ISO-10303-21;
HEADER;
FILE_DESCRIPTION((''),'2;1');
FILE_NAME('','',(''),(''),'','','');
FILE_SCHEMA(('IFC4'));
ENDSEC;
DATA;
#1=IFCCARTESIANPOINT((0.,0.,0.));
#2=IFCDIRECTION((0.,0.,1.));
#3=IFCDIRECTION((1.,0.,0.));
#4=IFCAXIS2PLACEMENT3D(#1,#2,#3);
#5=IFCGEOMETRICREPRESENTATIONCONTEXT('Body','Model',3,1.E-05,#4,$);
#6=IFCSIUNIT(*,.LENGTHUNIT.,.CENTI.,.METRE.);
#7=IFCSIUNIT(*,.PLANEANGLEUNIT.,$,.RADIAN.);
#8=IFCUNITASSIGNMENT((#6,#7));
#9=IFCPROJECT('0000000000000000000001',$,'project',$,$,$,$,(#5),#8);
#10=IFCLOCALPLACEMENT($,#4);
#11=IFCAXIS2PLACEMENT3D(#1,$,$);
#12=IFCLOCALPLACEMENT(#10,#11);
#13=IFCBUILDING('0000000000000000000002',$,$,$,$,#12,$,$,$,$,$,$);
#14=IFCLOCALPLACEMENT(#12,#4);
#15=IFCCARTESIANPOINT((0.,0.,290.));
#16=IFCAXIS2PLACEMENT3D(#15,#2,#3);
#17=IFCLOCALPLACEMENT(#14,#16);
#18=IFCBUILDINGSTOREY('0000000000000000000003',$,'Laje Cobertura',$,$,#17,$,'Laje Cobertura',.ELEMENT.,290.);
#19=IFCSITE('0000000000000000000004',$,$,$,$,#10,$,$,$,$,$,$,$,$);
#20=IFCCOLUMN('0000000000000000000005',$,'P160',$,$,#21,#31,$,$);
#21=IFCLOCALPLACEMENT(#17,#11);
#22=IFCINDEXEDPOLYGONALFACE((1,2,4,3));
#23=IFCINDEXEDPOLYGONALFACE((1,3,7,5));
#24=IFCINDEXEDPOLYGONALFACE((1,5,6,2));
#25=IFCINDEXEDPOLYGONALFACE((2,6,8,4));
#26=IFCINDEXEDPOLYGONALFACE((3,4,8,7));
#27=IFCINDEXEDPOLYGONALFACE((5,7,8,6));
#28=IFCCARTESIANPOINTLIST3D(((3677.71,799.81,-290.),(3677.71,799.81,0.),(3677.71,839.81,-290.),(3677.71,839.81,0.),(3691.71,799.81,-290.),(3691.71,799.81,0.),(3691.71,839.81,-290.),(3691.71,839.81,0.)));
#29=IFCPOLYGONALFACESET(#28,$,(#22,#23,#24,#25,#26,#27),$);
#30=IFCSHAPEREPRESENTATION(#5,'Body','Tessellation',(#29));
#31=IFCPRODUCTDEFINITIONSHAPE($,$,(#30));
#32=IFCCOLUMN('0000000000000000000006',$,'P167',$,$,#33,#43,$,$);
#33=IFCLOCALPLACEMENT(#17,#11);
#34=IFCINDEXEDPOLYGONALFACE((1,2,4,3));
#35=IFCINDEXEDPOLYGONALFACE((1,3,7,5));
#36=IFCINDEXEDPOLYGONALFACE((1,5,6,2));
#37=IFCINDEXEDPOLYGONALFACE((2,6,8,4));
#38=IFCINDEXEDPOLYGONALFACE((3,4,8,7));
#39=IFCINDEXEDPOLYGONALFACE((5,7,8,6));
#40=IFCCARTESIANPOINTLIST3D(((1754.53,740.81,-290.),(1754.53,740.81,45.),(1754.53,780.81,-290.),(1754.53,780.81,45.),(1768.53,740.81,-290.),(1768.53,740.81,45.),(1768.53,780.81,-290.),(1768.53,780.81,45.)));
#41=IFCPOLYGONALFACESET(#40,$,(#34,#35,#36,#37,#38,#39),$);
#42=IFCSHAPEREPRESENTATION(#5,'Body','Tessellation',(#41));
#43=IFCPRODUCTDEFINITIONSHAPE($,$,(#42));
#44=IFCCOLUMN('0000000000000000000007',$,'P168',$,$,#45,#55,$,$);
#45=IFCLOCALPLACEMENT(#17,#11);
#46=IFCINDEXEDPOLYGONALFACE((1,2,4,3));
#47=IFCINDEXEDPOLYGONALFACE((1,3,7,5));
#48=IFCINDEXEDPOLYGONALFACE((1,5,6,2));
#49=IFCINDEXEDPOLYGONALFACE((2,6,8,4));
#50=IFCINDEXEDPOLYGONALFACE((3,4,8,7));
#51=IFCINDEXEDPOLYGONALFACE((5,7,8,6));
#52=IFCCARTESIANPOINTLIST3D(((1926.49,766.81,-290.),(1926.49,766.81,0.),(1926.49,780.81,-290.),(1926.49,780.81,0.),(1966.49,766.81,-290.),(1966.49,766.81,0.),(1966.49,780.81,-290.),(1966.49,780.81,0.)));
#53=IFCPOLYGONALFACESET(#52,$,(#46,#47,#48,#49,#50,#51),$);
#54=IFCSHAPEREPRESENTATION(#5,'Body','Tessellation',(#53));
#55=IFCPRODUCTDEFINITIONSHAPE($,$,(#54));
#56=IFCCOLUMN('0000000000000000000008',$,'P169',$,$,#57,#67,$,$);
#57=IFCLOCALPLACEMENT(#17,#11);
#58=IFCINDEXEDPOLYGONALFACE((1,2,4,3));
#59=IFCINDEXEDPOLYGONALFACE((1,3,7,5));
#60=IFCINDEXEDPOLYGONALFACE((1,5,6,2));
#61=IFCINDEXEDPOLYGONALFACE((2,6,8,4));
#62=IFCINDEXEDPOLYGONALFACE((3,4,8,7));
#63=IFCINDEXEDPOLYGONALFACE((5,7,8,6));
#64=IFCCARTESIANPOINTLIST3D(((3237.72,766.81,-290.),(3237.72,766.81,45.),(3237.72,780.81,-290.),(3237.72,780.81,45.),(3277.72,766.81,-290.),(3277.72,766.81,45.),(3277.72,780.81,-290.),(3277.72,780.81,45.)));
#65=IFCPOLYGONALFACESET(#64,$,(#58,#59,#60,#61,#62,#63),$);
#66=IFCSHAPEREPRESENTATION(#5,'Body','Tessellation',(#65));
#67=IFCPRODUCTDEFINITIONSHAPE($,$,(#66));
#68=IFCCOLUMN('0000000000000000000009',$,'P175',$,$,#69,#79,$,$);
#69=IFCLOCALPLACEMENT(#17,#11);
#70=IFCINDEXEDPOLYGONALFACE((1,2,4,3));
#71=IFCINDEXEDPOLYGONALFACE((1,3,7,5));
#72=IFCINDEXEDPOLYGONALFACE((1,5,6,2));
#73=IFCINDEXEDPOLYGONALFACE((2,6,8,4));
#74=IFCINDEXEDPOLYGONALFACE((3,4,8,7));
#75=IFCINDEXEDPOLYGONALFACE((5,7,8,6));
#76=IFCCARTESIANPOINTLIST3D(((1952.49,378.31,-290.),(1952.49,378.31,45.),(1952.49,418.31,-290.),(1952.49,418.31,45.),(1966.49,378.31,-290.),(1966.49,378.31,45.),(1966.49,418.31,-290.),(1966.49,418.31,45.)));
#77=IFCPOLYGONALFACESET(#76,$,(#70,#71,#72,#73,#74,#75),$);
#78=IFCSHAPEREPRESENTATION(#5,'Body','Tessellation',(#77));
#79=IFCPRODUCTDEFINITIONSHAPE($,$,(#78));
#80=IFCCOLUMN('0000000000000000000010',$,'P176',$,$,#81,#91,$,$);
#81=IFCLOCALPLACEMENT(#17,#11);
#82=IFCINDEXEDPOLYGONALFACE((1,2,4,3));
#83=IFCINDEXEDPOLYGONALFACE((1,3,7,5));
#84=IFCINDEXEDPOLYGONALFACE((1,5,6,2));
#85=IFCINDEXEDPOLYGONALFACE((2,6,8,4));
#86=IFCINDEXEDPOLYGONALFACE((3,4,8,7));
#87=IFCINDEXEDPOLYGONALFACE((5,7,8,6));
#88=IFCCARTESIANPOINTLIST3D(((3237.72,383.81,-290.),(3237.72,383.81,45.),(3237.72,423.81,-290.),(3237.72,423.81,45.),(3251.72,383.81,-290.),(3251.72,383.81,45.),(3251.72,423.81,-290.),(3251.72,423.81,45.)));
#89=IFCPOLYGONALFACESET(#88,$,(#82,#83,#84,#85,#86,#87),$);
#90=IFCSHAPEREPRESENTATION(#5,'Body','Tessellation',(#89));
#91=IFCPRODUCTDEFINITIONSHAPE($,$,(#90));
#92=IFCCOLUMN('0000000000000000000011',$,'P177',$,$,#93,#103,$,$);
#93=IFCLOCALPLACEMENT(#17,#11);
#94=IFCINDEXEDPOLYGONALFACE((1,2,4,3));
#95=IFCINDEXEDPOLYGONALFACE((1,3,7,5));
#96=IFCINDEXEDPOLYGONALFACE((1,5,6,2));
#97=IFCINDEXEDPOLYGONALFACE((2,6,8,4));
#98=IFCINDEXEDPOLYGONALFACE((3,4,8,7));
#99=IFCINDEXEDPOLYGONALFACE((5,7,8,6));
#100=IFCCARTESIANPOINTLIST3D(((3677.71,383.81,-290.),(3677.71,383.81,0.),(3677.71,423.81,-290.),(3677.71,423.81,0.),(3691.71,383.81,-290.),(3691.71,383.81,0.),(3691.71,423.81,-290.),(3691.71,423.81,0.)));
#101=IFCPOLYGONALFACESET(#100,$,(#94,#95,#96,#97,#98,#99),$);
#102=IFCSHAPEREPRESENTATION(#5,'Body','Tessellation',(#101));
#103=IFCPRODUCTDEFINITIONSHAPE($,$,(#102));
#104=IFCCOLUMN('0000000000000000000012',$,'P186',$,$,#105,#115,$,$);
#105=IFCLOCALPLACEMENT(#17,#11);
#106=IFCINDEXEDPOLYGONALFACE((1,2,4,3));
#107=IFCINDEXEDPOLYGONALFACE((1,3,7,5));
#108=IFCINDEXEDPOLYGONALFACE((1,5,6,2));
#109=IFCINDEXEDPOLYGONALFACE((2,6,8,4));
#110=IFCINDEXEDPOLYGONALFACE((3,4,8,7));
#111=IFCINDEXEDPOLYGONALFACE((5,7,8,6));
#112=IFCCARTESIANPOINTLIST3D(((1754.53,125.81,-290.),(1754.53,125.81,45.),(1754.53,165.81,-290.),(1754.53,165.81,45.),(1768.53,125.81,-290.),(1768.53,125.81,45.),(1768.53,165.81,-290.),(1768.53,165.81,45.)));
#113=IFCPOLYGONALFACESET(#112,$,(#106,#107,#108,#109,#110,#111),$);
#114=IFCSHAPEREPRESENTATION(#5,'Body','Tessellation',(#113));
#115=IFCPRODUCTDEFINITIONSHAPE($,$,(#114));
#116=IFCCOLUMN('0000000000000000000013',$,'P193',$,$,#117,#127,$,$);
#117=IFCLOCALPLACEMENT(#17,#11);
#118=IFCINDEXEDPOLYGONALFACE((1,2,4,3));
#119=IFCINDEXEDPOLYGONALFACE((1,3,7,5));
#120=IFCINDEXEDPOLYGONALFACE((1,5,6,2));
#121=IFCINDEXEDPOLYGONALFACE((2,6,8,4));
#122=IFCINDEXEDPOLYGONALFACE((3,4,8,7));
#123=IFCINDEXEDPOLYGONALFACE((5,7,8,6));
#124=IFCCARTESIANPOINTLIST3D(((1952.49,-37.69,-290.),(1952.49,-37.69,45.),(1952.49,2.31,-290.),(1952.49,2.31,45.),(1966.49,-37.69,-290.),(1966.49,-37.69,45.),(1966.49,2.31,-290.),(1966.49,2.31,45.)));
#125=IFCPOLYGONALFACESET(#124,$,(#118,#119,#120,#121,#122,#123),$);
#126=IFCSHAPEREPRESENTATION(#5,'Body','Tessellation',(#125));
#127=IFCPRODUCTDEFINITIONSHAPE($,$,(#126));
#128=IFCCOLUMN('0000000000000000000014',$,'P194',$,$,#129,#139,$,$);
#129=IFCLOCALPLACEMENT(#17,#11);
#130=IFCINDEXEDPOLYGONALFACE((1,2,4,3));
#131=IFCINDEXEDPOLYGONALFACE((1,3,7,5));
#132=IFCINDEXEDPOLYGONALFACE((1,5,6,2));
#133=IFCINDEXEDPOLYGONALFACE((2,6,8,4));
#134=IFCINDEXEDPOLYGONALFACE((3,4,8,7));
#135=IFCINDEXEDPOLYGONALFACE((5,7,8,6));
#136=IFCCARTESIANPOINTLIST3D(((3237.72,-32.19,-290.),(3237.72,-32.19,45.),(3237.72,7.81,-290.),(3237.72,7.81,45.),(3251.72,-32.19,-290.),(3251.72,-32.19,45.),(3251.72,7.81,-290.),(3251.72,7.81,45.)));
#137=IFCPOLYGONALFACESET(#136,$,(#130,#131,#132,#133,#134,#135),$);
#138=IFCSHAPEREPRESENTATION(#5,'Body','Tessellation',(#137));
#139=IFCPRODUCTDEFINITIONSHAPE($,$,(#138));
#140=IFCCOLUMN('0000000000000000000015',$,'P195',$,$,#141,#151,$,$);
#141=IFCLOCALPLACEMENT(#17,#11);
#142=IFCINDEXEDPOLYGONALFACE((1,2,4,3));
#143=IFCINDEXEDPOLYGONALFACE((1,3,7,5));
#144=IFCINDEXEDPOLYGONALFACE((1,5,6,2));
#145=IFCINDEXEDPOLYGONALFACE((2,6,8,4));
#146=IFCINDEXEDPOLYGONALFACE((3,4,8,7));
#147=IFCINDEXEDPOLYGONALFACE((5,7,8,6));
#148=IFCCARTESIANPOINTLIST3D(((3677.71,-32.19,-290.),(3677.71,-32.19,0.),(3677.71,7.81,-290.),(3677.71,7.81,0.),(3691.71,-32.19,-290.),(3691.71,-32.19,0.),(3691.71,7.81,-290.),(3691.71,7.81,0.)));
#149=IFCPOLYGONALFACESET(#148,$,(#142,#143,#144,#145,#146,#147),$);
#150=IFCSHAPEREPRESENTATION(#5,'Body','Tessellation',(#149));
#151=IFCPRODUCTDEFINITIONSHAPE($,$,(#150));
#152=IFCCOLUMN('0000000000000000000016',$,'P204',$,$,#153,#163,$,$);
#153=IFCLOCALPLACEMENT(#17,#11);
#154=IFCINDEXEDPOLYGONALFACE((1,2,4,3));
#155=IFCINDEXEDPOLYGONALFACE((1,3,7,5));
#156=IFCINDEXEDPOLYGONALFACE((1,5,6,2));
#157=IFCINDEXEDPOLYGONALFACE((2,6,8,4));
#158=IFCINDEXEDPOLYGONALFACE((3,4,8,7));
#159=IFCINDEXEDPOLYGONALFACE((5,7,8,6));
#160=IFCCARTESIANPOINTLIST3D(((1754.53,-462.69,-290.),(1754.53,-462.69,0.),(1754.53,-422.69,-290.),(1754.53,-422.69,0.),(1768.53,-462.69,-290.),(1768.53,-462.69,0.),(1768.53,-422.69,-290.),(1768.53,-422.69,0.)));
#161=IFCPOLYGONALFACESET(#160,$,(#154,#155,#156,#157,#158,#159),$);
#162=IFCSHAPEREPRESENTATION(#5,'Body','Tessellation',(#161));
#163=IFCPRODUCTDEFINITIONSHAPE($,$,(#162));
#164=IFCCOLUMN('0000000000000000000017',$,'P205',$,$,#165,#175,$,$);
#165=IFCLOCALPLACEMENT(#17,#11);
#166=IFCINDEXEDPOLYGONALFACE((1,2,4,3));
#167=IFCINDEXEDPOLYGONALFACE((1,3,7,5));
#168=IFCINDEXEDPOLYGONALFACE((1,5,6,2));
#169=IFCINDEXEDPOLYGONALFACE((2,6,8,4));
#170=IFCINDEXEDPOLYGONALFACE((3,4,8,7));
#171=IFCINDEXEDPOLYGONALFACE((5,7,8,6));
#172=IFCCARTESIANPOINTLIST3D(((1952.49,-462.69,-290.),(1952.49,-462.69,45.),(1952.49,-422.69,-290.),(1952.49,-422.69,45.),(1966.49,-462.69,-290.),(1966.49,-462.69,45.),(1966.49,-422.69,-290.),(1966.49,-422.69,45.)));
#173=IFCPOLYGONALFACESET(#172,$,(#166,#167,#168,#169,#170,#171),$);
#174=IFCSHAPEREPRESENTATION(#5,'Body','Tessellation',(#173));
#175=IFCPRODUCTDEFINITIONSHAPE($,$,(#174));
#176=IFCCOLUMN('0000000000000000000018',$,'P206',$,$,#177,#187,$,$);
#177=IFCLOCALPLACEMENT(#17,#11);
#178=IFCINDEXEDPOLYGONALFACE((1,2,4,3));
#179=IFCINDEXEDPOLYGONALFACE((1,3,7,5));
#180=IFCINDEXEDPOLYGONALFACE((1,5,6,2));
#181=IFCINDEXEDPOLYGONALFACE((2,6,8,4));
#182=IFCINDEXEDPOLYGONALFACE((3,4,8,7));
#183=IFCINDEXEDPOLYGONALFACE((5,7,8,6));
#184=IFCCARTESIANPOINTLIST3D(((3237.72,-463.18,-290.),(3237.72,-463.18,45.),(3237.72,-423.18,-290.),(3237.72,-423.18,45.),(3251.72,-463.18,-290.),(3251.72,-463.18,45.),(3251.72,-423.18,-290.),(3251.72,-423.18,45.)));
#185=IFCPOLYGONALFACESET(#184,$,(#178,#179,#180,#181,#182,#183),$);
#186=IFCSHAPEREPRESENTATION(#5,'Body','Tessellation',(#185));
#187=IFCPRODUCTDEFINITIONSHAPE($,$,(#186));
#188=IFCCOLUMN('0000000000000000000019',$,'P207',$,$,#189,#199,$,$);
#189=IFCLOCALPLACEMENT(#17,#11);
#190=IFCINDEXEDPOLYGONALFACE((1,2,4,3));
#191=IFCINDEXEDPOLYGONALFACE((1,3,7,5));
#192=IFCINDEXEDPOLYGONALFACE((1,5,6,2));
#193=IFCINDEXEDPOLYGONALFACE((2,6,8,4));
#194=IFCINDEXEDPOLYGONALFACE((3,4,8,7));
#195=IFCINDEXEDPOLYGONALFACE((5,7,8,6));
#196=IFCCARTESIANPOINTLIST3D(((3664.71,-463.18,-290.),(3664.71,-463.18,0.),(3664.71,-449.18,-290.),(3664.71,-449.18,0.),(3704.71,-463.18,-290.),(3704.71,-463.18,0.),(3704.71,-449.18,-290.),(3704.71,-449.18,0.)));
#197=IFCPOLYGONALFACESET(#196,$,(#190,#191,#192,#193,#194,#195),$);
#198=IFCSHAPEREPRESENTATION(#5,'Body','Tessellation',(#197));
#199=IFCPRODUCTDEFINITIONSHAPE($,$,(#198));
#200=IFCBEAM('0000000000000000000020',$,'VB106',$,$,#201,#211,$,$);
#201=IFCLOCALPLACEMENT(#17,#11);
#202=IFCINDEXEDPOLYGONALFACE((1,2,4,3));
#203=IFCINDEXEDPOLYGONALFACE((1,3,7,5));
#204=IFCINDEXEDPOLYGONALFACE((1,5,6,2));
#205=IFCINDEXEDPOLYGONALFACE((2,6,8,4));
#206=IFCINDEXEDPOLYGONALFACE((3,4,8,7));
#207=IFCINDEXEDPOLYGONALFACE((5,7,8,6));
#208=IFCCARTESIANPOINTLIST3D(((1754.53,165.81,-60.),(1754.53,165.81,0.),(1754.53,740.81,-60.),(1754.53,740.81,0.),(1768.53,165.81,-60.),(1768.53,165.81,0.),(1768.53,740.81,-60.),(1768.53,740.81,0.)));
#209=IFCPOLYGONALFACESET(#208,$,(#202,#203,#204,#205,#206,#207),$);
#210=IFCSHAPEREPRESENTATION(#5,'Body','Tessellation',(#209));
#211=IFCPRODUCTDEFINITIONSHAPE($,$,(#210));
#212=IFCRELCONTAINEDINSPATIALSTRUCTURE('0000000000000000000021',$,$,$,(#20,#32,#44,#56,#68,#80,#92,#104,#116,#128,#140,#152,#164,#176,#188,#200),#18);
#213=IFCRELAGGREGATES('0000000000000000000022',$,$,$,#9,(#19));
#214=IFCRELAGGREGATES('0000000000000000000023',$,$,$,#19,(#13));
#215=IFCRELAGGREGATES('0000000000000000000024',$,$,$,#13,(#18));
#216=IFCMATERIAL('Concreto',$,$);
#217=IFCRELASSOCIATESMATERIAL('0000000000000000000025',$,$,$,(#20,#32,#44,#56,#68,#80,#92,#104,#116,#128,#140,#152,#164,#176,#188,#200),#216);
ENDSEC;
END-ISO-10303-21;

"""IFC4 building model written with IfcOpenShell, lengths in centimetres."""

from ifc_helpers import new_model, si_unit, frame, origin, origin_with_axes, origin_2d_with_axis, place, context, project, spatial, rectangle, extrude, material, element, save


model = new_model("IFC4")

# Units and contexts
model_context = context("Model", 3, precision=1e-05, world=origin_with_axes(), identifier="Body")
ifc_project = project(units=[si_unit("LENGTHUNIT", "METRE", prefix="CENTI"), si_unit("PLANEANGLEUNIT", "RADIAN")], contexts=[model_context])

# Site, building, storey
site_placement = place(None, origin_with_axes())
site = spatial("IfcSite", under=ifc_project, at=site_placement)
building_placement = place(site_placement, origin())
building = spatial("IfcBuilding", under=site, at=building_placement)
placement = place(building_placement, origin_with_axes())
storey_placement = place(placement, frame((0.0, 0.0, 290.0), z_axis=(0.0, 0.0, 1.0), x_axis=(1.0, 0.0, 0.0)))
storey = spatial("IfcBuildingStorey", under=building, at=storey_placement, Name="Laje Cobertura", LongName="Laje Cobertura", CompositionType="ELEMENT", Elevation=290.0)

# Columns
ifc_material = material(Name="Concreto")
column_1_placement = place(storey_placement, frame((3684.71, 819.81, 0.0), z_axis=(0.0, 0.0, 1.0), x_axis=(1.0, 0.0, 0.0)))
element("IfcColumn", 1, at=column_1_placement, inside=storey, material=ifc_material, Name="P160", context=model_context, shape_type="SolidModel", body=[
    extrude(rectangle(XDim=14.0, YDim=40.0, at=origin_2d_with_axis()), origin_with_axes(), (0.0, 0.0, -1.0), 290.0),
])
column_2_placement = place(storey_placement, frame((1761.53, 760.81, 45.0), z_axis=(0.0, 0.0, 1.0), x_axis=(1.0, 0.0, 0.0)))
element("IfcColumn", 2, at=column_2_placement, inside=storey, material=ifc_material, Name="P167", context=model_context, shape_type="SolidModel", body=[
    extrude(rectangle(XDim=14.0, YDim=40.0, at=origin_2d_with_axis()), origin_with_axes(), (0.0, 0.0, -1.0), 335.0),
])
column_3_placement = place(storey_placement, frame((1946.49, 773.81, 0.0), z_axis=(0.0, 0.0, 1.0), x_axis=(1.0, 0.0, 0.0)))
element("IfcColumn", 3, at=column_3_placement, inside=storey, material=ifc_material, Name="P168", context=model_context, shape_type="SolidModel", body=[
    extrude(rectangle(XDim=14.0, YDim=40.0, at=origin_2d_with_axis()), frame((0.0, 0.0, 0.0), z_axis=(0.0, 0.0, 1.0), x_axis=(0.0, -1.0, 0.0)), (0.0, 0.0, -1.0), 290.0),
])
column_4_placement = place(storey_placement, frame((3257.72, 773.81, 45.0), z_axis=(0.0, 0.0, 1.0), x_axis=(1.0, 0.0, 0.0)))
element("IfcColumn", 4, at=column_4_placement, inside=storey, material=ifc_material, Name="P169", context=model_context, shape_type="SolidModel", body=[
    extrude(rectangle(XDim=14.0, YDim=40.0, at=origin_2d_with_axis()), frame((0.0, 0.0, 0.0), z_axis=(0.0, 0.0, 1.0), x_axis=(0.0, -1.0, 0.0)), (0.0, 0.0, -1.0), 335.0),
])
for number, where, z_axis, x_axis, name in (
    (5, (1959.49, 398.31, 45.0), (0.0, 0.0, 1.0), (1.0, 0.0, 0.0), "P175"),
    (6, (3244.72, 403.81, 45.0), (0.0, 0.0, 1.0), (1.0, 0.0, 0.0), "P176"),
):
    element("IfcColumn", number, at=place(storey_placement, frame(where, z_axis=z_axis, x_axis=x_axis)), inside=storey, material=ifc_material, Name=name, context=model_context, shape_type="SolidModel", body=[
        extrude(rectangle(XDim=14.0, YDim=40.0, at=origin_2d_with_axis()), origin_with_axes(), (0.0, 0.0, -1.0), 335.0),
    ])
column_5_placement = place(storey_placement, frame((3684.71, 403.81, 0.0), z_axis=(0.0, 0.0, 1.0), x_axis=(1.0, 0.0, 0.0)))
element("IfcColumn", 7, at=column_5_placement, inside=storey, material=ifc_material, Name="P177", context=model_context, shape_type="SolidModel", body=[
    extrude(rectangle(XDim=14.0, YDim=40.0, at=origin_2d_with_axis()), origin_with_axes(), (0.0, 0.0, -1.0), 290.0),
])
for number, where, z_axis, x_axis, name in (
    (8, (1761.53, 145.81, 45.0), (0.0, 0.0, 1.0), (1.0, 0.0, 0.0), "P186"),
    (9, (1959.49, -17.69, 45.0), (0.0, 0.0, 1.0), (1.0, 0.0, 0.0), "P193"),
    (10, (3244.72, -12.19, 45.0), (0.0, 0.0, 1.0), (1.0, 0.0, 0.0), "P194"),
):
    element("IfcColumn", number, at=place(storey_placement, frame(where, z_axis=z_axis, x_axis=x_axis)), inside=storey, material=ifc_material, Name=name, context=model_context, shape_type="SolidModel", body=[
        extrude(rectangle(XDim=14.0, YDim=40.0, at=origin_2d_with_axis()), origin_with_axes(), (0.0, 0.0, -1.0), 335.0),
    ])
for number, where, z_axis, x_axis, name in (
    (11, (3684.71, -12.19, 0.0), (0.0, 0.0, 1.0), (1.0, 0.0, 0.0), "P195"),
    (12, (1761.53, -442.69, 0.0), (0.0, 0.0, 1.0), (1.0, 0.0, 0.0), "P204"),
):
    element("IfcColumn", number, at=place(storey_placement, frame(where, z_axis=z_axis, x_axis=x_axis)), inside=storey, material=ifc_material, Name=name, context=model_context, shape_type="SolidModel", body=[
        extrude(rectangle(XDim=14.0, YDim=40.0, at=origin_2d_with_axis()), origin_with_axes(), (0.0, 0.0, -1.0), 290.0),
    ])
for number, where, z_axis, x_axis, name in (
    (13, (1959.49, -442.69, 45.0), (0.0, 0.0, 1.0), (1.0, 0.0, 0.0), "P205"),
    (14, (3244.72, -443.18, 45.0), (0.0, 0.0, 1.0), (1.0, 0.0, 0.0), "P206"),
):
    element("IfcColumn", number, at=place(storey_placement, frame(where, z_axis=z_axis, x_axis=x_axis)), inside=storey, material=ifc_material, Name=name, context=model_context, shape_type="SolidModel", body=[
        extrude(rectangle(XDim=14.0, YDim=40.0, at=origin_2d_with_axis()), origin_with_axes(), (0.0, 0.0, -1.0), 335.0),
    ])
column_6_placement = place(storey_placement, frame((3684.71, -456.18, 0.0), z_axis=(0.0, 0.0, 1.0), x_axis=(1.0, 0.0, 0.0)))
element("IfcColumn", 15, at=column_6_placement, inside=storey, material=ifc_material, Name="P207", context=model_context, shape_type="SolidModel", body=[
    extrude(rectangle(XDim=14.0, YDim=40.0, at=origin_2d_with_axis()), frame((0.0, 0.0, 0.0), z_axis=(0.0, 0.0, 1.0), x_axis=(0.0, -1.0, 0.0)), (0.0, 0.0, -1.0), 290.0),
])

# Beam
beam_1_placement = place(storey_placement, frame((1761.53, 453.31, 0.0), z_axis=(0.0, 0.0, 1.0), x_axis=(1.0, 0.0, 0.0)))
element("IfcBeam", 16, at=beam_1_placement, inside=storey, material=ifc_material, Name="VB106", context=model_context, shape_type="SolidModel", body=[
    extrude(rectangle(XDim=14.0, YDim=60.0, at=origin_2d_with_axis()), frame((0.0, -287.5, -30.0), z_axis=(0.0, 1.0, 0.0), x_axis=(1.0, 0.0, 0.0)), (0.0, 0.0, 1.0), 575.0),
])

save(model, "model.ifc")
